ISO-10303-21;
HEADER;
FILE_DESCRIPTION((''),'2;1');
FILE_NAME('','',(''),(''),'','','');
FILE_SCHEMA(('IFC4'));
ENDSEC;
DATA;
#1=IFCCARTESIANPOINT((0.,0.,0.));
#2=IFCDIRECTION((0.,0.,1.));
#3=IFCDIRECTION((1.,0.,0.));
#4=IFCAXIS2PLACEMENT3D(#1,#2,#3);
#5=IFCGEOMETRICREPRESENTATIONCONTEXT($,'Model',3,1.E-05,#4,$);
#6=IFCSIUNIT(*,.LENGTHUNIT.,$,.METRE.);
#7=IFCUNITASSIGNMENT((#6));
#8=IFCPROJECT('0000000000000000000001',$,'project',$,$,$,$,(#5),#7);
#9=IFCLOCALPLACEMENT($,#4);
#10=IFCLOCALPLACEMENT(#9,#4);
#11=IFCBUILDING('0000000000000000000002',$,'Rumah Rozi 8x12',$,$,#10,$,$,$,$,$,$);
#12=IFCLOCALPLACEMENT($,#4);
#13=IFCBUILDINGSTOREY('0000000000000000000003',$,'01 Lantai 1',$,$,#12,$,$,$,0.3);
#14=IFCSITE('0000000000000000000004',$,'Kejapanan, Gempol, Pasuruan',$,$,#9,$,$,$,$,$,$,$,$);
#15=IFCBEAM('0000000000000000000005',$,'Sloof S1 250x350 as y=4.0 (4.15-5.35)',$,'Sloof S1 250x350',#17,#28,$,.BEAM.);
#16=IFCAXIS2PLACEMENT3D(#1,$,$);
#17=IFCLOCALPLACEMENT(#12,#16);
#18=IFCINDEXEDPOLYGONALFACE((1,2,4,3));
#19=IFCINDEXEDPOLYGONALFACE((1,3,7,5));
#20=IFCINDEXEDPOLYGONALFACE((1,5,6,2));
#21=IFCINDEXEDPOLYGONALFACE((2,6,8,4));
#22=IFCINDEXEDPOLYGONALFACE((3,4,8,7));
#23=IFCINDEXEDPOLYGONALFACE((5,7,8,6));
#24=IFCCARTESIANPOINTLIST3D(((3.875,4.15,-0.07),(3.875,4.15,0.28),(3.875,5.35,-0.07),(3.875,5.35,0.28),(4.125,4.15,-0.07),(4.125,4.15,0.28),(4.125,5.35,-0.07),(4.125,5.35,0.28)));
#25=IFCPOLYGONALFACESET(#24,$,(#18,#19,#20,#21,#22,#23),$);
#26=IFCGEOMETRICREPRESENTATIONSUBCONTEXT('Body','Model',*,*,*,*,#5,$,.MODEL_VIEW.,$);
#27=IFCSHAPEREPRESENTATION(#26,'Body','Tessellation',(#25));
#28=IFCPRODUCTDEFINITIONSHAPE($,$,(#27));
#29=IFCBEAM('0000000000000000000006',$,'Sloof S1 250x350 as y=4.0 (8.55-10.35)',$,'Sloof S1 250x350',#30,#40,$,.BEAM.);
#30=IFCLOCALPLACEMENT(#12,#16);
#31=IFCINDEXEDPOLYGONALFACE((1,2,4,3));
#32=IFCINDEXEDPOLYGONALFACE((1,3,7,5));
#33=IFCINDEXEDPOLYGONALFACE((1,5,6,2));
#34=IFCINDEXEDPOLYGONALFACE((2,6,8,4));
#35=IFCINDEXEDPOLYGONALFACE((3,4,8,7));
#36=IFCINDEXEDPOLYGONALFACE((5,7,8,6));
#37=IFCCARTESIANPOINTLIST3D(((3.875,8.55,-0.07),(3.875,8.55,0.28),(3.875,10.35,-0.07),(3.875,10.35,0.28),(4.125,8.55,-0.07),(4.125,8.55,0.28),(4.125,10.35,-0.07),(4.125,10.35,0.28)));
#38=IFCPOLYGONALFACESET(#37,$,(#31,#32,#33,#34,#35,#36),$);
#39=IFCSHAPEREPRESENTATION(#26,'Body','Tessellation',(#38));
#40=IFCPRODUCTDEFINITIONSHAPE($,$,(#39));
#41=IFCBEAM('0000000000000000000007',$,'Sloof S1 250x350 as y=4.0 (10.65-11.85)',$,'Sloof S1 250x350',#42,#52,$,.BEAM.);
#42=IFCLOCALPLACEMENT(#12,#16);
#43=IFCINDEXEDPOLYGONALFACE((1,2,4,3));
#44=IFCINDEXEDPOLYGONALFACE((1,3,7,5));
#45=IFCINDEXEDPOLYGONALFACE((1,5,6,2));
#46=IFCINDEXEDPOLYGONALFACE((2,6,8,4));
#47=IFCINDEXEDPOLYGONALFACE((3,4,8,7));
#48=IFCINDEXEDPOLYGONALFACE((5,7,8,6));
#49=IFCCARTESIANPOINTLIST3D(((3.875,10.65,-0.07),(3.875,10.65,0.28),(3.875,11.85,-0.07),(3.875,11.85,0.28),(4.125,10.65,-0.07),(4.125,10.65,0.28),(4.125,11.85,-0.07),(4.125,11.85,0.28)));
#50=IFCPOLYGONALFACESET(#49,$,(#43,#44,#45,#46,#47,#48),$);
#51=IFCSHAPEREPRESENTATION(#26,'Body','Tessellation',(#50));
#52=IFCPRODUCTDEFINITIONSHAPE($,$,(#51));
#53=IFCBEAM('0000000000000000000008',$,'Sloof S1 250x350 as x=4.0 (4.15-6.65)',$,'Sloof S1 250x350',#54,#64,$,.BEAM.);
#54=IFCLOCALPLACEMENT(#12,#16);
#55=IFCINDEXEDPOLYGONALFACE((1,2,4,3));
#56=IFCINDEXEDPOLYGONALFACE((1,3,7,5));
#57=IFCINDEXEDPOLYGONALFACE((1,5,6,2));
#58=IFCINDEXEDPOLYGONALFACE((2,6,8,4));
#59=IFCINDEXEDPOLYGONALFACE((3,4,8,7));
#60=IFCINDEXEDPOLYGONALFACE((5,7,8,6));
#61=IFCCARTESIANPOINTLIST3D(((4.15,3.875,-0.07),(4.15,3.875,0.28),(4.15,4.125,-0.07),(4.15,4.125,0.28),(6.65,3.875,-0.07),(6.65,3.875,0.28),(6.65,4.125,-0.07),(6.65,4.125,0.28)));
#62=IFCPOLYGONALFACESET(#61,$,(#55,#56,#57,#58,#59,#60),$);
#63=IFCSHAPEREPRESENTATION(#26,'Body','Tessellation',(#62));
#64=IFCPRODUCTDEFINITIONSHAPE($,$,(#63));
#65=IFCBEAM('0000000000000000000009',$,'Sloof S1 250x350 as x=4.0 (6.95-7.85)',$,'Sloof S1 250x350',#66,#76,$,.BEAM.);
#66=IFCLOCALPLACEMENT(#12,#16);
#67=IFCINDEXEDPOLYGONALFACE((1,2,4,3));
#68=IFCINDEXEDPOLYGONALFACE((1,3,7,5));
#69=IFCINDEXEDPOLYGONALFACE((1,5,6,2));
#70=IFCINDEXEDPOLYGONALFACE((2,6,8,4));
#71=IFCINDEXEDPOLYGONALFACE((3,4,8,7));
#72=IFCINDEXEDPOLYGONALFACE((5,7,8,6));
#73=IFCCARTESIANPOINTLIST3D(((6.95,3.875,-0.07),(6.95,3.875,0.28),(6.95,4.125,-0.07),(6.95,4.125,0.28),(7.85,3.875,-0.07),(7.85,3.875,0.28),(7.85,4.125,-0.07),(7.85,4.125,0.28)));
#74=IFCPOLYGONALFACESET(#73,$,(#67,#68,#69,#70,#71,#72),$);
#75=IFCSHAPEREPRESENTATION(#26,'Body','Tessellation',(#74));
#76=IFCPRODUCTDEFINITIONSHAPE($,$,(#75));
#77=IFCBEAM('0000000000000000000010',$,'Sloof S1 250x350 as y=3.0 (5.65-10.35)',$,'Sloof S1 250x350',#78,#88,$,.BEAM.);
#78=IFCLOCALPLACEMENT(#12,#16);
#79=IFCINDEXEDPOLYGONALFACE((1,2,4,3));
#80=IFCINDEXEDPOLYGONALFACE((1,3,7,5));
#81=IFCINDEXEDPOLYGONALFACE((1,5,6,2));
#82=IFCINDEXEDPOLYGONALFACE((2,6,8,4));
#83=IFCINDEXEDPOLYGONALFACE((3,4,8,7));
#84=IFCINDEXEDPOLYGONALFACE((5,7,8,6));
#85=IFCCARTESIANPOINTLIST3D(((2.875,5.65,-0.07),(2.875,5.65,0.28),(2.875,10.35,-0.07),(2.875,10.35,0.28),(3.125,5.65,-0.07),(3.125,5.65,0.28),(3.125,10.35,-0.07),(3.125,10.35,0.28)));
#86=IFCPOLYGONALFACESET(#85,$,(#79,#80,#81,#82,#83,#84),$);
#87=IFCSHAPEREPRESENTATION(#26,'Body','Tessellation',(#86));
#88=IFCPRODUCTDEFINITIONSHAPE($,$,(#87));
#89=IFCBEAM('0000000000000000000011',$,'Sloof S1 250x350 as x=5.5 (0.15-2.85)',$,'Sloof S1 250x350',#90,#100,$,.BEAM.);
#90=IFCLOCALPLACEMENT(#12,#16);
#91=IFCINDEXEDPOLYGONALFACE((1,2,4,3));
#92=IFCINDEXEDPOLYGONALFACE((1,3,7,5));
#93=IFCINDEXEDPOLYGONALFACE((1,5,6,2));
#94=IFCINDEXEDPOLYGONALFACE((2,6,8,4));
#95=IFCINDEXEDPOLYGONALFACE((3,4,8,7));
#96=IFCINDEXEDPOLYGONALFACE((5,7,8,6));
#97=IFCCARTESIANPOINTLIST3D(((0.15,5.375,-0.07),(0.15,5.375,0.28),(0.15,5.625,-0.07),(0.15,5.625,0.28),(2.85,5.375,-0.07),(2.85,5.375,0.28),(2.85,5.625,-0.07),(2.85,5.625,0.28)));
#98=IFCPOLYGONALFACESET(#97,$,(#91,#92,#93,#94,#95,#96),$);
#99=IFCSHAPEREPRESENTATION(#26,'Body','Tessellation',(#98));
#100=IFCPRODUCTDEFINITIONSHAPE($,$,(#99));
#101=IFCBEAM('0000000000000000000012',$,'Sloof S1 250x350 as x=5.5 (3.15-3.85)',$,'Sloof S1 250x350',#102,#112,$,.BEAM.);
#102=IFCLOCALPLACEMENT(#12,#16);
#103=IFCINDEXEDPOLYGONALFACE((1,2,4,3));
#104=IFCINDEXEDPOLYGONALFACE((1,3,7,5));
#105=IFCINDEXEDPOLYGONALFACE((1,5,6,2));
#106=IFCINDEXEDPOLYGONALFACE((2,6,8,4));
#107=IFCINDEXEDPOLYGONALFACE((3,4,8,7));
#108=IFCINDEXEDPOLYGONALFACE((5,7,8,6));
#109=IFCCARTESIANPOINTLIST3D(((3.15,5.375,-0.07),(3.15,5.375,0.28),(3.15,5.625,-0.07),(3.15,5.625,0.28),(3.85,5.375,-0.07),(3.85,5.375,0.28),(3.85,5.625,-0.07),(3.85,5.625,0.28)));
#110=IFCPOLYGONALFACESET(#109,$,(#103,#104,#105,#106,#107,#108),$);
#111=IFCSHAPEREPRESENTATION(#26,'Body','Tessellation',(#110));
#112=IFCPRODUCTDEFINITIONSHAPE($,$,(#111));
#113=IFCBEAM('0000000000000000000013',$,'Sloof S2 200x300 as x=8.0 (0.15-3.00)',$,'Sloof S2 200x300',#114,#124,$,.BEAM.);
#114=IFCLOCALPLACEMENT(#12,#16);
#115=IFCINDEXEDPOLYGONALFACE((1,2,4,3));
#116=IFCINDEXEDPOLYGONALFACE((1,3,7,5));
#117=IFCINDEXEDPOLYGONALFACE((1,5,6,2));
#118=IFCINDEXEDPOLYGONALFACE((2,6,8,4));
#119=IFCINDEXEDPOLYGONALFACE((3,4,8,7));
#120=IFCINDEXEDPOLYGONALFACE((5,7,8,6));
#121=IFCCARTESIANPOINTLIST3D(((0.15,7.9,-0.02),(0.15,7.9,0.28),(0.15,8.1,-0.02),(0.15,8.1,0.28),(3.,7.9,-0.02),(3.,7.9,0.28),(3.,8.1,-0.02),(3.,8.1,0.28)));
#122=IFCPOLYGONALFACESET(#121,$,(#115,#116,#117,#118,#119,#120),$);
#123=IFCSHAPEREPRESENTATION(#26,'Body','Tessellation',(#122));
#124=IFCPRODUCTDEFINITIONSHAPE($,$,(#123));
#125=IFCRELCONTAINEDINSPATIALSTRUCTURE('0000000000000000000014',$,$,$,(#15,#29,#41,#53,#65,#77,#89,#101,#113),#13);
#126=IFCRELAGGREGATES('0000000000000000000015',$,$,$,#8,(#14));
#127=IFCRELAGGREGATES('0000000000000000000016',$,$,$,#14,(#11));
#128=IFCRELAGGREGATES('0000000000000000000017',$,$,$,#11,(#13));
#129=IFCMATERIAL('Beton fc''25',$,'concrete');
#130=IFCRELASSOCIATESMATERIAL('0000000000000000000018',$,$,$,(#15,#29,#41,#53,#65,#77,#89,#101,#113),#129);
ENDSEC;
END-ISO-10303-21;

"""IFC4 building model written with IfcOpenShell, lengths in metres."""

from ifc_helpers import new_model, si_unit, frame, origin_with_axes, place, context, subcontext, project, spatial, line, indexed_curve, outline, extrude, material, element, save


model = new_model("IFC4")

# Units and contexts
model_context = context("Model", 3, precision=1e-05, world=origin_with_axes())
body_context = subcontext(model_context, "Body", "Model", "MODEL_VIEW")
ifc_project = project(units=[si_unit("LENGTHUNIT", "METRE")], contexts=[model_context])

# Site, building, storey
site_placement = place(None, origin_with_axes())
site = spatial("IfcSite", under=ifc_project, at=site_placement, Name="Kejapanan, Gempol, Pasuruan")
building_placement = place(site_placement, origin_with_axes())
building = spatial("IfcBuilding", under=site, at=building_placement, Name="Rumah Rozi 8x12")
storey_placement = place(None, origin_with_axes())
storey = spatial("IfcBuildingStorey", under=building, at=storey_placement, Name="01 Lantai 1", Elevation=0.3)

# Beams
ifc_material = material(Name="Beton fc'25", Category="concrete")
beam_1_placement = place(storey_placement, origin_with_axes())
element("IfcBeam", 1, at=beam_1_placement, inside=storey, material=ifc_material, Name="Sloof S1 250x350 as y=4.0 (4.15-5.35)", ObjectType="Sloof S1 250x350", PredefinedType="BEAM", context=body_context, shape_type="SweptSolid", body=[
    extrude(outline(indexed_curve([(3.875, 4.15), (4.125, 4.15), (4.125, 5.35), (3.875, 5.35)], segments=[line(1, 2, 3, 4, 1)])), frame((0.0, 0.0, -0.07), z_axis=(0.0, 0.0, 1.0), x_axis=(1.0, 0.0, 0.0)), (0.0, 0.0, 1.0), 0.35),
])
beam_2_placement = place(storey_placement, origin_with_axes())
element("IfcBeam", 2, at=beam_2_placement, inside=storey, material=ifc_material, Name="Sloof S1 250x350 as y=4.0 (8.55-10.35)", ObjectType="Sloof S1 250x350", PredefinedType="BEAM", context=body_context, shape_type="SweptSolid", body=[
    extrude(outline(indexed_curve([(3.875, 8.55), (4.125, 8.55), (4.125, 10.35), (3.875, 10.35)], segments=[line(1, 2, 3, 4, 1)])), frame((0.0, 0.0, -0.07), z_axis=(0.0, 0.0, 1.0), x_axis=(1.0, 0.0, 0.0)), (0.0, 0.0, 1.0), 0.35),
])
beam_3_placement = place(storey_placement, origin_with_axes())
element("IfcBeam", 3, at=beam_3_placement, inside=storey, material=ifc_material, Name="Sloof S1 250x350 as y=4.0 (10.65-11.85)", ObjectType="Sloof S1 250x350", PredefinedType="BEAM", context=body_context, shape_type="SweptSolid", body=[
    extrude(outline(indexed_curve([(3.875, 10.65), (4.125, 10.65), (4.125, 11.85), (3.875, 11.85)], segments=[line(1, 2, 3, 4, 1)])), frame((0.0, 0.0, -0.07), z_axis=(0.0, 0.0, 1.0), x_axis=(1.0, 0.0, 0.0)), (0.0, 0.0, 1.0), 0.35),
])
beam_4_placement = place(storey_placement, origin_with_axes())
element("IfcBeam", 4, at=beam_4_placement, inside=storey, material=ifc_material, Name="Sloof S1 250x350 as x=4.0 (4.15-6.65)", ObjectType="Sloof S1 250x350", PredefinedType="BEAM", context=body_context, shape_type="SweptSolid", body=[
    extrude(outline(indexed_curve([(4.15, 3.875), (6.65, 3.875), (6.65, 4.125), (4.15, 4.125)], segments=[line(1, 2, 3, 4, 1)])), frame((0.0, 0.0, -0.07), z_axis=(0.0, 0.0, 1.0), x_axis=(1.0, 0.0, 0.0)), (0.0, 0.0, 1.0), 0.35),
])
beam_5_placement = place(storey_placement, origin_with_axes())
element("IfcBeam", 5, at=beam_5_placement, inside=storey, material=ifc_material, Name="Sloof S1 250x350 as x=4.0 (6.95-7.85)", ObjectType="Sloof S1 250x350", PredefinedType="BEAM", context=body_context, shape_type="SweptSolid", body=[
    extrude(outline(indexed_curve([(6.95, 3.875), (7.85, 3.875), (7.85, 4.125), (6.95, 4.125)], segments=[line(1, 2, 3, 4, 1)])), frame((0.0, 0.0, -0.07), z_axis=(0.0, 0.0, 1.0), x_axis=(1.0, 0.0, 0.0)), (0.0, 0.0, 1.0), 0.35),
])
beam_6_placement = place(storey_placement, origin_with_axes())
element("IfcBeam", 6, at=beam_6_placement, inside=storey, material=ifc_material, Name="Sloof S1 250x350 as y=3.0 (5.65-10.35)", ObjectType="Sloof S1 250x350", PredefinedType="BEAM", context=body_context, shape_type="SweptSolid", body=[
    extrude(outline(indexed_curve([(2.875, 5.65), (3.125, 5.65), (3.125, 10.35), (2.875, 10.35)], segments=[line(1, 2, 3, 4, 1)])), frame((0.0, 0.0, -0.07), z_axis=(0.0, 0.0, 1.0), x_axis=(1.0, 0.0, 0.0)), (0.0, 0.0, 1.0), 0.35),
])
beam_7_placement = place(storey_placement, origin_with_axes())
element("IfcBeam", 7, at=beam_7_placement, inside=storey, material=ifc_material, Name="Sloof S1 250x350 as x=5.5 (0.15-2.85)", ObjectType="Sloof S1 250x350", PredefinedType="BEAM", context=body_context, shape_type="SweptSolid", body=[
    extrude(outline(indexed_curve([(0.15, 5.375), (2.85, 5.375), (2.85, 5.625), (0.15, 5.625)], segments=[line(1, 2, 3, 4, 1)])), frame((0.0, 0.0, -0.07), z_axis=(0.0, 0.0, 1.0), x_axis=(1.0, 0.0, 0.0)), (0.0, 0.0, 1.0), 0.35),
])
beam_8_placement = place(storey_placement, origin_with_axes())
element("IfcBeam", 8, at=beam_8_placement, inside=storey, material=ifc_material, Name="Sloof S1 250x350 as x=5.5 (3.15-3.85)", ObjectType="Sloof S1 250x350", PredefinedType="BEAM", context=body_context, shape_type="SweptSolid", body=[
    extrude(outline(indexed_curve([(3.15, 5.375), (3.85, 5.375), (3.85, 5.625), (3.15, 5.625)], segments=[line(1, 2, 3, 4, 1)])), frame((0.0, 0.0, -0.07), z_axis=(0.0, 0.0, 1.0), x_axis=(1.0, 0.0, 0.0)), (0.0, 0.0, 1.0), 0.35),
])
beam_9_placement = place(storey_placement, origin_with_axes())
element("IfcBeam", 9, at=beam_9_placement, inside=storey, material=ifc_material, Name="Sloof S2 200x300 as x=8.0 (0.15-3.00)", ObjectType="Sloof S2 200x300", PredefinedType="BEAM", context=body_context, shape_type="SweptSolid", body=[
    extrude(outline(indexed_curve([(0.15, 7.9), (3.0, 7.9), (3.0, 8.1), (0.15, 8.1)], segments=[line(1, 2, 3, 4, 1)])), frame((0.0, 0.0, -0.02), z_axis=(0.0, 0.0, 1.0), x_axis=(1.0, 0.0, 0.0)), (0.0, 0.0, 1.0), 0.3),
])

save(model, "model.ifc")
